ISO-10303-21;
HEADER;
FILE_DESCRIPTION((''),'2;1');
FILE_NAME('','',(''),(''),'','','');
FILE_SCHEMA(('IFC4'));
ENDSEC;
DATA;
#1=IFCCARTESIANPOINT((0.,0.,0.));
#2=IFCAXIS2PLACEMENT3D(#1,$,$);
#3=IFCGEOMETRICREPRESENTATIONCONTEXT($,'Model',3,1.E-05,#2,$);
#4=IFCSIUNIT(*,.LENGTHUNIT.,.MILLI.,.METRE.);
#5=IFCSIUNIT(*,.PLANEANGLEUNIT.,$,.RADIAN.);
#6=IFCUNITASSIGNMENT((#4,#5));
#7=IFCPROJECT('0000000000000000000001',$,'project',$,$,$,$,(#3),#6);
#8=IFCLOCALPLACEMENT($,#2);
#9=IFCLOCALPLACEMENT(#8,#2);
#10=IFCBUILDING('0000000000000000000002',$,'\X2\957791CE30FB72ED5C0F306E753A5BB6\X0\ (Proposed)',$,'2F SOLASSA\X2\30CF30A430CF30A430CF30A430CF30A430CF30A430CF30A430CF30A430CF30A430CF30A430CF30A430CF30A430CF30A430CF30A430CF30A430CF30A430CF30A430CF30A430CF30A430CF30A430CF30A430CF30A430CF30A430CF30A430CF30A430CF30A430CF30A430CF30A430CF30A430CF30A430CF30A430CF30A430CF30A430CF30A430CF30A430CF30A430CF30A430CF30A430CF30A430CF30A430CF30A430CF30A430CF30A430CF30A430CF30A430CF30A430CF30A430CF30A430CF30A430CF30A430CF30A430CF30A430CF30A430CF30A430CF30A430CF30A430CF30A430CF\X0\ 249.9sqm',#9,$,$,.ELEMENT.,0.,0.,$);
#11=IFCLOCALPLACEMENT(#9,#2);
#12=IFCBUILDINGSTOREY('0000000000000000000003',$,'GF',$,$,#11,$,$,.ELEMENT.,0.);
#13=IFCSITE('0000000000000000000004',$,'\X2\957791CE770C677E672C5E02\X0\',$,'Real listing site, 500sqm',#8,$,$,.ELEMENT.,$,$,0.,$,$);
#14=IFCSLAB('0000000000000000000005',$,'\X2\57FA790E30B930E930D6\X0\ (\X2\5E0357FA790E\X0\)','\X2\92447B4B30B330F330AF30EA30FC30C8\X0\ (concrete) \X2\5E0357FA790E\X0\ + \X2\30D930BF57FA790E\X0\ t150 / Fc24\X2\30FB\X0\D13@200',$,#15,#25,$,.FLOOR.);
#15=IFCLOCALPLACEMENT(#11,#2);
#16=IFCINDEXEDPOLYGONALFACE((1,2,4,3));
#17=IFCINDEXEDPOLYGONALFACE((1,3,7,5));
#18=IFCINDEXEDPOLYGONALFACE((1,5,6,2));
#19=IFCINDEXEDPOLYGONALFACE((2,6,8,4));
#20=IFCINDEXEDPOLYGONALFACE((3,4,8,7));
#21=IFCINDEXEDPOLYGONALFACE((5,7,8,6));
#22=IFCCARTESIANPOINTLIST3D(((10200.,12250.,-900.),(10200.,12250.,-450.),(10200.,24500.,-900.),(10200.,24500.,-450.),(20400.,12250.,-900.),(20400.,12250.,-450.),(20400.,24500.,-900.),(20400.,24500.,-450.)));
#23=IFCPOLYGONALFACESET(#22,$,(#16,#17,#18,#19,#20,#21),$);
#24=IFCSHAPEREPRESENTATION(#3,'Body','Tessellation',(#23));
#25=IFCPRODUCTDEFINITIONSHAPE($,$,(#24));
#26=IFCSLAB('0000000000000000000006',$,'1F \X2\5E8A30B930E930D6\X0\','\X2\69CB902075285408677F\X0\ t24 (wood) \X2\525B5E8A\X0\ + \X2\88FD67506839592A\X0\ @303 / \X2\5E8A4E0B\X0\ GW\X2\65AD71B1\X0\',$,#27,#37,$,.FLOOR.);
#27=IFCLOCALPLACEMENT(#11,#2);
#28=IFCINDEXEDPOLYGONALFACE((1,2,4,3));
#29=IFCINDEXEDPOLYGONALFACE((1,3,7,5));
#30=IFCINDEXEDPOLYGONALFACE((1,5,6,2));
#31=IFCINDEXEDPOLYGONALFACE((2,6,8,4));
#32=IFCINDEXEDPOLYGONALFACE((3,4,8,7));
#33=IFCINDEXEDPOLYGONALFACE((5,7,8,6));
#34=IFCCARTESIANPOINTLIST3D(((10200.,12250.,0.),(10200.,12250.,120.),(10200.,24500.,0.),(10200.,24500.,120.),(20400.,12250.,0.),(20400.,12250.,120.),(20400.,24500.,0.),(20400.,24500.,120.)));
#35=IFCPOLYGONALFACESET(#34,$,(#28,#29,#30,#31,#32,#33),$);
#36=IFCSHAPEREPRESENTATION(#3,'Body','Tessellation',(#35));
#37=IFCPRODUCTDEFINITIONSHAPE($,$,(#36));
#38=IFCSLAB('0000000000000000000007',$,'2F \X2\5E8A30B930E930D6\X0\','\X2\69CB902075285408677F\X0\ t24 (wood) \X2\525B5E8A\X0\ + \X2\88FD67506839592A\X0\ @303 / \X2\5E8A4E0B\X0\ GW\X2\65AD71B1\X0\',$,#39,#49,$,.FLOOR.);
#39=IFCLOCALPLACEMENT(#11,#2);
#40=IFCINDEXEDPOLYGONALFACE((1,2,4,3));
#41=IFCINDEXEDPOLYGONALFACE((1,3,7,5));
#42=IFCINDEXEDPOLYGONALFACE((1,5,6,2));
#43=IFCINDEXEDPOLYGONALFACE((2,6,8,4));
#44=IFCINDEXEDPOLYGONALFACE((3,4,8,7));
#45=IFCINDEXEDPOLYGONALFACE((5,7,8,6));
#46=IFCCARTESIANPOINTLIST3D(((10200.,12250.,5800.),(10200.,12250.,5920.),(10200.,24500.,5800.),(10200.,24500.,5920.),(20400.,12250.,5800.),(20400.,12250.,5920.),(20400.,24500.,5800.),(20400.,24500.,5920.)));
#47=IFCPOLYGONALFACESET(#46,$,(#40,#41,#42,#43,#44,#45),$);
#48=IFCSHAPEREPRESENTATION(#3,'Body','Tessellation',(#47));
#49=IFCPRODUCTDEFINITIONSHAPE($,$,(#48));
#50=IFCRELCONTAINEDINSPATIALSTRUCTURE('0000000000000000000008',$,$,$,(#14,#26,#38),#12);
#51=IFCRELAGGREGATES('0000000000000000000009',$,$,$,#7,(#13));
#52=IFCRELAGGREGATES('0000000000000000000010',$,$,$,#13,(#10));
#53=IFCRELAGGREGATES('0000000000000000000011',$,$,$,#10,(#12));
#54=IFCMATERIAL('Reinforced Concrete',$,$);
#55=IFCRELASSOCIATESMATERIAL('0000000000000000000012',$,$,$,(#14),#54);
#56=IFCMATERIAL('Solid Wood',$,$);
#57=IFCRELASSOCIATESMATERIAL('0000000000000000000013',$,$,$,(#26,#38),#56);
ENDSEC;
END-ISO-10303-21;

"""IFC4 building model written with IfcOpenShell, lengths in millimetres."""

from ifc_helpers import new_model, si_unit, frame, frame_2d, origin, place, context, project, spatial, rectangle, extrude, material, element, save


model = new_model("IFC4")

# Units and contexts
model_context = context("Model", 3, precision=1e-05, world=origin())
ifc_project = project(units=[si_unit("LENGTHUNIT", "METRE", prefix="MILLI"), si_unit("PLANEANGLEUNIT", "RADIAN")], contexts=[model_context])

# Site, building, storey
site_placement = place(None, origin())
site = spatial("IfcSite", under=ifc_project, at=site_placement, Name="長野県松本市", ObjectType="Real listing site, 500sqm", CompositionType="ELEMENT", RefElevation=0.0)
building_placement = place(site_placement, origin())
building = spatial("IfcBuilding", under=site, at=building_placement, Name="長野・狭小の町家 (Proposed)", ObjectType="2F SOLASSAハイハイハイハイハイハイハイハイハイハイハイハイハイハイハイハイハイハイハイハイハイハイハイハイハイハイハイハイハイハイハイハイハイハイハイハイハイハイハイハイハイハイハイハイハイハイハイハイハイハイハイハイハイハイハイハイハ 249.9sqm", CompositionType="ELEMENT", ElevationOfRefHeight=0.0, ElevationOfTerrain=0.0)
storey_placement = place(building_placement, origin())
storey = spatial("IfcBuildingStorey", under=building, at=storey_placement, Name="GF", CompositionType="ELEMENT", Elevation=0.0)

# Shared definitions
ifc_material_1 = material(Name="Solid Wood")

# Slabs
ifc_material_2 = material(Name="Reinforced Concrete")
slab_1_placement = place(storey_placement, frame((5100.0, 6125.0, -450.0)))
element("IfcSlab", 1, at=slab_1_placement, inside=storey, material=ifc_material_2, Name="基礎スラブ (布基礎)", Description="鉄筋コンクリート (concrete) 布基礎 + ベタ基礎 t150 / Fc24・D13@200", PredefinedType="FLOOR", context=model_context, shape_type="SweptSolid", body=[
    extrude(rectangle(XDim=10200.0, YDim=12250.0, at=frame_2d((5100.0, 6125.0))), frame((5100.0, 6125.0, -450.0)), (0.0, 0.0, 1.0), 450.0),
])
slab_2_placement = place(storey_placement, frame((5100.0, 6125.0, 0.0)))
element("IfcSlab", 2, at=slab_2_placement, inside=storey, material=ifc_material_1, Name="1F 床スラブ", Description="構造用合板 t24 (wood) 剛床 + 製材根太 @303 / 床下 GW断熱", PredefinedType="FLOOR", context=model_context, shape_type="SweptSolid", body=[
    extrude(rectangle(XDim=10200.0, YDim=12250.0, at=frame_2d((5100.0, 6125.0))), frame((5100.0, 6125.0, 0.0)), (0.0, 0.0, 1.0), 120.0),
])
slab_3_placement = place(storey_placement, frame((5100.0, 6125.0, 2900.0)))
element("IfcSlab", 3, at=slab_3_placement, inside=storey, material=ifc_material_1, Name="2F 床スラブ", Description="構造用合板 t24 (wood) 剛床 + 製材根太 @303 / 床下 GW断熱", PredefinedType="FLOOR", context=model_context, shape_type="SweptSolid", body=[
    extrude(rectangle(XDim=10200.0, YDim=12250.0, at=frame_2d((5100.0, 6125.0))), frame((5100.0, 6125.0, 2900.0)), (0.0, 0.0, 1.0), 120.0),
])

save(model, "model.ifc")
